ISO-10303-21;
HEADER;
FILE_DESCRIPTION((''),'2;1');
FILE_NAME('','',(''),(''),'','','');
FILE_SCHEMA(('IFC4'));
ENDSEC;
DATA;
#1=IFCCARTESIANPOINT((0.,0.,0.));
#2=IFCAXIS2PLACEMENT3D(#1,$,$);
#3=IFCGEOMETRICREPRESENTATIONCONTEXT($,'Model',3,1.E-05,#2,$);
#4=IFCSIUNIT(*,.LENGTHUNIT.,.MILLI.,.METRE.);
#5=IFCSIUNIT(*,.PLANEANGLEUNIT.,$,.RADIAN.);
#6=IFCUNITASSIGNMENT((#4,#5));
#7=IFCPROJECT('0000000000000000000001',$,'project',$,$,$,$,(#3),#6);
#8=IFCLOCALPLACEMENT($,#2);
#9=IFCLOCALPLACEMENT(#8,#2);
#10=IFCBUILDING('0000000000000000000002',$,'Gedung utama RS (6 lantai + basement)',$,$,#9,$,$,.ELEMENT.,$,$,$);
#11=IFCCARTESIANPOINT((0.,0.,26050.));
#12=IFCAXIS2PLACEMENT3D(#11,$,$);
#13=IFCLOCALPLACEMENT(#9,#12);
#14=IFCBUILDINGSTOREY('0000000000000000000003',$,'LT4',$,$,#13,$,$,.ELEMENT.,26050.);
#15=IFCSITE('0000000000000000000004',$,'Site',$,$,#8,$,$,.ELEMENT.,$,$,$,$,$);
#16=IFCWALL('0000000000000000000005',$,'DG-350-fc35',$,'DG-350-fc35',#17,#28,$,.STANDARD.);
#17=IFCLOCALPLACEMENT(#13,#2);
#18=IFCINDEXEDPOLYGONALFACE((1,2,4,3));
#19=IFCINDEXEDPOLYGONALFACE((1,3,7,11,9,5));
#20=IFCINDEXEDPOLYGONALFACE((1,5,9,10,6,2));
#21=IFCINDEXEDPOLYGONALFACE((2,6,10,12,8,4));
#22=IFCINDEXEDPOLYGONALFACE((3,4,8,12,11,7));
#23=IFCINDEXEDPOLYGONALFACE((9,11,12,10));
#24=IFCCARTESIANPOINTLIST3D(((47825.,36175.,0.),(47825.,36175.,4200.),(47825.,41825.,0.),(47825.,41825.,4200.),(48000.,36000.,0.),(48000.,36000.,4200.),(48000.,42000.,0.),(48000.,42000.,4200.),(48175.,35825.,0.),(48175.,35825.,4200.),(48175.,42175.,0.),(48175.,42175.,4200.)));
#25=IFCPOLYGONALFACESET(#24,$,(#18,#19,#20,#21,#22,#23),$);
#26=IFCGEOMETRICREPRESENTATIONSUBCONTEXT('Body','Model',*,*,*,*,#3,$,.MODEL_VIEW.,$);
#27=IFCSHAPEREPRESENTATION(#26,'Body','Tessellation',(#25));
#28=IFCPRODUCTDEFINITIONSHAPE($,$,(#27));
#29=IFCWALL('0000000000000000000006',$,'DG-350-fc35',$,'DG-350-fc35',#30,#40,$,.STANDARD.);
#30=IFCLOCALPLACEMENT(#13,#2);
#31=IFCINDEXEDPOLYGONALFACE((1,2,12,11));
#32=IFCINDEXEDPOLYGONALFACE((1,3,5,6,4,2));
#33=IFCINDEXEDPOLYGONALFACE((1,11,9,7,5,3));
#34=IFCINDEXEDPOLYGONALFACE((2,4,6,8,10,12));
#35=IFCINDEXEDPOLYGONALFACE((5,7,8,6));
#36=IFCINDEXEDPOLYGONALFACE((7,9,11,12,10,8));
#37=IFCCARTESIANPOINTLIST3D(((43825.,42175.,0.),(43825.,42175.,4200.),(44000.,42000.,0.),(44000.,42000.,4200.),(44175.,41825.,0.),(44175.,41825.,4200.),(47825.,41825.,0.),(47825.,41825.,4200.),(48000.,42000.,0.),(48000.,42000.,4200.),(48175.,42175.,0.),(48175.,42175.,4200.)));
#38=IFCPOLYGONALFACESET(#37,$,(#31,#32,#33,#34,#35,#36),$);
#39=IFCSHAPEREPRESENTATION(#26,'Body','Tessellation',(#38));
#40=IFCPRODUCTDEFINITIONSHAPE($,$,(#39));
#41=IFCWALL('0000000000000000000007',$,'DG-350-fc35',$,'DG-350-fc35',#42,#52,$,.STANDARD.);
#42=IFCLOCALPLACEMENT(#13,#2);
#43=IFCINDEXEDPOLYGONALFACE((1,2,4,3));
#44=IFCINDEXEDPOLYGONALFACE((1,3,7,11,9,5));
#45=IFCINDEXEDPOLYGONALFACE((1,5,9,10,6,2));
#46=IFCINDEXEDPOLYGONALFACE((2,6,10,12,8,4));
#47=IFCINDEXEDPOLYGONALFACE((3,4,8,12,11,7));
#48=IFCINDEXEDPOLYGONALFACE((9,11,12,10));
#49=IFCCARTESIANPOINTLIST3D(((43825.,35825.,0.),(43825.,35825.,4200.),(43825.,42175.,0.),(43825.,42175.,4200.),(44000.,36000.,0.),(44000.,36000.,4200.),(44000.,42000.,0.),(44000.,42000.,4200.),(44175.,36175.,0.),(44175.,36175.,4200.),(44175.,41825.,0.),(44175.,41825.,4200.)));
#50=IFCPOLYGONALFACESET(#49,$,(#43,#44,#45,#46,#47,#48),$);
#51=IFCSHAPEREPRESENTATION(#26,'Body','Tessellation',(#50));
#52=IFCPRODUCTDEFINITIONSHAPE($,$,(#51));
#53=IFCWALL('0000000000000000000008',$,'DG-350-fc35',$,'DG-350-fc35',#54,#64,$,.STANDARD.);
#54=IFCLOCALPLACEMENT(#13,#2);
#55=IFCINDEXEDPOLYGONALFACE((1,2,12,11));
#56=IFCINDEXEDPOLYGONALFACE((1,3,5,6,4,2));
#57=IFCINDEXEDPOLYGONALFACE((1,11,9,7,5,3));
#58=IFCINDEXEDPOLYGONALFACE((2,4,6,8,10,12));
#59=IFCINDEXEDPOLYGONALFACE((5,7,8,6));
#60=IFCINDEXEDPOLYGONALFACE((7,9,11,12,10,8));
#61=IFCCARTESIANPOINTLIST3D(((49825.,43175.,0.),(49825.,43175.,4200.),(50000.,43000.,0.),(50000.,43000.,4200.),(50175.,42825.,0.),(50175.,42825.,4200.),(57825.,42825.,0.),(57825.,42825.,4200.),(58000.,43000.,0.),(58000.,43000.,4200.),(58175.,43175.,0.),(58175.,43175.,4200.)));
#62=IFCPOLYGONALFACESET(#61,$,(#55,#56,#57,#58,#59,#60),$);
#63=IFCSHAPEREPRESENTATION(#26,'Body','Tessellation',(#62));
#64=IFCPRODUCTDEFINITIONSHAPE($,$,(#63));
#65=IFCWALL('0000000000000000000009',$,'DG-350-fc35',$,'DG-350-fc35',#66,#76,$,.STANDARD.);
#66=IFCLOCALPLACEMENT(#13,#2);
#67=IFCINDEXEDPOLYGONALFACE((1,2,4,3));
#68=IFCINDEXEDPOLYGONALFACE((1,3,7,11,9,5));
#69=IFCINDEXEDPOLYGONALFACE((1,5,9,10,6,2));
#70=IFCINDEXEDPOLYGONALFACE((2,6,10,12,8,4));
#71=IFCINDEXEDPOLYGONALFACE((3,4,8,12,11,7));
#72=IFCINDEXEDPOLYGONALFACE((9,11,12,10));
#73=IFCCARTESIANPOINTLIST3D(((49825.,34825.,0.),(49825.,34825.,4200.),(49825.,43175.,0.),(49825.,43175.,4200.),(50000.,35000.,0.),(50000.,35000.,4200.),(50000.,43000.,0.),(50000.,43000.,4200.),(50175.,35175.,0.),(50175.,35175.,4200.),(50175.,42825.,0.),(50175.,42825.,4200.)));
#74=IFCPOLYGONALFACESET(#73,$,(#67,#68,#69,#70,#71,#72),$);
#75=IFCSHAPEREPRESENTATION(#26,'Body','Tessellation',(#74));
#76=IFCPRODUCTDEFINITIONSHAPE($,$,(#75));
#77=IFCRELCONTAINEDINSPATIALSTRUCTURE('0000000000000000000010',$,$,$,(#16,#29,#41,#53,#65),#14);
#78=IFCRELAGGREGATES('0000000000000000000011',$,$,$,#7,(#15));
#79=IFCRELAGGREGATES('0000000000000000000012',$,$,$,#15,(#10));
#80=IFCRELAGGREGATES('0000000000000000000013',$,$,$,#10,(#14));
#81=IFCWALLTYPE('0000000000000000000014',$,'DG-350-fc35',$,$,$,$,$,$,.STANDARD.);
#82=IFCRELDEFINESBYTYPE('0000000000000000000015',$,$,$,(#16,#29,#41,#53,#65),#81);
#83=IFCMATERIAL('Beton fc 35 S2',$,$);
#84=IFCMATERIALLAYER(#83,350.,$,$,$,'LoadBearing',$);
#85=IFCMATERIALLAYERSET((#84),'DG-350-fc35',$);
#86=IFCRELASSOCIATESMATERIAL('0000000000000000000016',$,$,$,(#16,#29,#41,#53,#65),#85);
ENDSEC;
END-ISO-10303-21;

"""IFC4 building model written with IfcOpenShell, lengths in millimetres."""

from ifc_helpers import new_model, si_unit, frame, origin, place, context, subcontext, project, spatial, polyline, outline, extrude, material, layer, layer_set, layer_usage, type_object, element, save


model = new_model("IFC4")

# Units and contexts
model_context = context("Model", 3, precision=1e-05, world=origin())
body_context = subcontext(model_context, "Body", "Model", "MODEL_VIEW")
ifc_project = project(units=[si_unit("LENGTHUNIT", "METRE", prefix="MILLI"), si_unit("PLANEANGLEUNIT", "RADIAN")], contexts=[model_context])

# Site, building, storey
site_placement = place(None, origin())
site = spatial("IfcSite", under=ifc_project, at=site_placement, Name="Site", CompositionType="ELEMENT")
building_placement = place(site_placement, origin())
building = spatial("IfcBuilding", under=site, at=building_placement, Name="Gedung utama RS (6 lantai + basement)", CompositionType="ELEMENT")
storey_placement = place(building_placement, frame((0.0, 0.0, 26050.0)))
storey = spatial("IfcBuildingStorey", under=building, at=storey_placement, Name="LT4", CompositionType="ELEMENT", Elevation=26050.0)

# Shared definitions
ifc_material_1 = material(Name="Beton fc 35 S2")
ifc_layer = layer(ifc_material_1, 350.0, Category="LoadBearing")
ifc_layer_set = layer_set([ifc_layer], Name="DG-350-fc35")
ifc_layer_usage = layer_usage(ifc_layer_set, "AXIS2", "NEGATIVE", 175.0)
wall_type = type_object("IfcWallType", Name="DG-350-fc35", PredefinedType="STANDARD")

# Walls
wall_1_placement = place(storey_placement, frame((48000.0, 36000.0, 0.0), z_axis=(0.0, 0.0, 1.0), x_axis=(0.0, 1.0, 0.0)))
element("IfcWall", 1, at=wall_1_placement, inside=storey, type_object=wall_type, material=ifc_layer_usage, Name="DG-350-fc35", ObjectType="DG-350-fc35", PredefinedType="STANDARD", context=body_context, shape_type="SweptSolid", body=[
    extrude(outline(polyline([(-175.0, -175.0), (0.0, 0.0), (175.0, 175.0), (5825.0, 175.0), (6000.0, 0.0), (6175.0, -175.0), (-175.0, -175.0)])), origin(), (0.0, 0.0, 1.0), 4200.0),
])
wall_2_placement = place(storey_placement, frame((48000.0, 42000.0, 0.0), z_axis=(0.0, 0.0, 1.0), x_axis=(-1.0, 0.0, 0.0)))
element("IfcWall", 2, at=wall_2_placement, inside=storey, type_object=wall_type, material=ifc_layer_usage, Name="DG-350-fc35", ObjectType="DG-350-fc35", PredefinedType="STANDARD", context=body_context, shape_type="SweptSolid", body=[
    extrude(outline(polyline([(-175.0, -175.0), (0.0, 0.0), (175.0, 175.0), (3825.0, 175.0), (4000.0, 0.0), (4175.0, -175.0), (-175.0, -175.0)])), origin(), (0.0, 0.0, 1.0), 4200.0),
])
wall_3_placement = place(storey_placement, frame((44000.0, 42000.0, 0.0), z_axis=(0.0, 0.0, 1.0), x_axis=(0.0, -1.0, 0.0)))
element("IfcWall", 3, at=wall_3_placement, inside=storey, type_object=wall_type, material=ifc_layer_usage, Name="DG-350-fc35", ObjectType="DG-350-fc35", PredefinedType="STANDARD", context=body_context, shape_type="SweptSolid", body=[
    extrude(outline(polyline([(-175.0, -175.0), (0.0, 0.0), (175.0, 175.0), (5825.0, 175.0), (6000.0, 0.0), (6175.0, -175.0), (-175.0, -175.0)])), origin(), (0.0, 0.0, 1.0), 4200.0),
])
for number, where, z_axis, x_axis, name in (
    (4, (58000.0, 43000.0, 0.0), (0.0, 0.0, 1.0), (-1.0, 0.0, 0.0), "DG-350-fc35"),
    (5, (50000.0, 43000.0, 0.0), (0.0, 0.0, 1.0), (0.0, -1.0, 0.0), "DG-350-fc35"),
):
    element("IfcWall", number, at=place(storey_placement, frame(where, z_axis=z_axis, x_axis=x_axis)), inside=storey, type_object=wall_type, material=ifc_layer_usage, Name=name, ObjectType="DG-350-fc35", PredefinedType="STANDARD", context=body_context, shape_type="SweptSolid", body=[
        extrude(outline(polyline([(-175.0, -175.0), (0.0, 0.0), (175.0, 175.0), (7825.0, 175.0), (8000.0, 0.0), (8175.0, -175.0), (-175.0, -175.0)])), origin(), (0.0, 0.0, 1.0), 4200.0),
    ])

save(model, "model.ifc")
